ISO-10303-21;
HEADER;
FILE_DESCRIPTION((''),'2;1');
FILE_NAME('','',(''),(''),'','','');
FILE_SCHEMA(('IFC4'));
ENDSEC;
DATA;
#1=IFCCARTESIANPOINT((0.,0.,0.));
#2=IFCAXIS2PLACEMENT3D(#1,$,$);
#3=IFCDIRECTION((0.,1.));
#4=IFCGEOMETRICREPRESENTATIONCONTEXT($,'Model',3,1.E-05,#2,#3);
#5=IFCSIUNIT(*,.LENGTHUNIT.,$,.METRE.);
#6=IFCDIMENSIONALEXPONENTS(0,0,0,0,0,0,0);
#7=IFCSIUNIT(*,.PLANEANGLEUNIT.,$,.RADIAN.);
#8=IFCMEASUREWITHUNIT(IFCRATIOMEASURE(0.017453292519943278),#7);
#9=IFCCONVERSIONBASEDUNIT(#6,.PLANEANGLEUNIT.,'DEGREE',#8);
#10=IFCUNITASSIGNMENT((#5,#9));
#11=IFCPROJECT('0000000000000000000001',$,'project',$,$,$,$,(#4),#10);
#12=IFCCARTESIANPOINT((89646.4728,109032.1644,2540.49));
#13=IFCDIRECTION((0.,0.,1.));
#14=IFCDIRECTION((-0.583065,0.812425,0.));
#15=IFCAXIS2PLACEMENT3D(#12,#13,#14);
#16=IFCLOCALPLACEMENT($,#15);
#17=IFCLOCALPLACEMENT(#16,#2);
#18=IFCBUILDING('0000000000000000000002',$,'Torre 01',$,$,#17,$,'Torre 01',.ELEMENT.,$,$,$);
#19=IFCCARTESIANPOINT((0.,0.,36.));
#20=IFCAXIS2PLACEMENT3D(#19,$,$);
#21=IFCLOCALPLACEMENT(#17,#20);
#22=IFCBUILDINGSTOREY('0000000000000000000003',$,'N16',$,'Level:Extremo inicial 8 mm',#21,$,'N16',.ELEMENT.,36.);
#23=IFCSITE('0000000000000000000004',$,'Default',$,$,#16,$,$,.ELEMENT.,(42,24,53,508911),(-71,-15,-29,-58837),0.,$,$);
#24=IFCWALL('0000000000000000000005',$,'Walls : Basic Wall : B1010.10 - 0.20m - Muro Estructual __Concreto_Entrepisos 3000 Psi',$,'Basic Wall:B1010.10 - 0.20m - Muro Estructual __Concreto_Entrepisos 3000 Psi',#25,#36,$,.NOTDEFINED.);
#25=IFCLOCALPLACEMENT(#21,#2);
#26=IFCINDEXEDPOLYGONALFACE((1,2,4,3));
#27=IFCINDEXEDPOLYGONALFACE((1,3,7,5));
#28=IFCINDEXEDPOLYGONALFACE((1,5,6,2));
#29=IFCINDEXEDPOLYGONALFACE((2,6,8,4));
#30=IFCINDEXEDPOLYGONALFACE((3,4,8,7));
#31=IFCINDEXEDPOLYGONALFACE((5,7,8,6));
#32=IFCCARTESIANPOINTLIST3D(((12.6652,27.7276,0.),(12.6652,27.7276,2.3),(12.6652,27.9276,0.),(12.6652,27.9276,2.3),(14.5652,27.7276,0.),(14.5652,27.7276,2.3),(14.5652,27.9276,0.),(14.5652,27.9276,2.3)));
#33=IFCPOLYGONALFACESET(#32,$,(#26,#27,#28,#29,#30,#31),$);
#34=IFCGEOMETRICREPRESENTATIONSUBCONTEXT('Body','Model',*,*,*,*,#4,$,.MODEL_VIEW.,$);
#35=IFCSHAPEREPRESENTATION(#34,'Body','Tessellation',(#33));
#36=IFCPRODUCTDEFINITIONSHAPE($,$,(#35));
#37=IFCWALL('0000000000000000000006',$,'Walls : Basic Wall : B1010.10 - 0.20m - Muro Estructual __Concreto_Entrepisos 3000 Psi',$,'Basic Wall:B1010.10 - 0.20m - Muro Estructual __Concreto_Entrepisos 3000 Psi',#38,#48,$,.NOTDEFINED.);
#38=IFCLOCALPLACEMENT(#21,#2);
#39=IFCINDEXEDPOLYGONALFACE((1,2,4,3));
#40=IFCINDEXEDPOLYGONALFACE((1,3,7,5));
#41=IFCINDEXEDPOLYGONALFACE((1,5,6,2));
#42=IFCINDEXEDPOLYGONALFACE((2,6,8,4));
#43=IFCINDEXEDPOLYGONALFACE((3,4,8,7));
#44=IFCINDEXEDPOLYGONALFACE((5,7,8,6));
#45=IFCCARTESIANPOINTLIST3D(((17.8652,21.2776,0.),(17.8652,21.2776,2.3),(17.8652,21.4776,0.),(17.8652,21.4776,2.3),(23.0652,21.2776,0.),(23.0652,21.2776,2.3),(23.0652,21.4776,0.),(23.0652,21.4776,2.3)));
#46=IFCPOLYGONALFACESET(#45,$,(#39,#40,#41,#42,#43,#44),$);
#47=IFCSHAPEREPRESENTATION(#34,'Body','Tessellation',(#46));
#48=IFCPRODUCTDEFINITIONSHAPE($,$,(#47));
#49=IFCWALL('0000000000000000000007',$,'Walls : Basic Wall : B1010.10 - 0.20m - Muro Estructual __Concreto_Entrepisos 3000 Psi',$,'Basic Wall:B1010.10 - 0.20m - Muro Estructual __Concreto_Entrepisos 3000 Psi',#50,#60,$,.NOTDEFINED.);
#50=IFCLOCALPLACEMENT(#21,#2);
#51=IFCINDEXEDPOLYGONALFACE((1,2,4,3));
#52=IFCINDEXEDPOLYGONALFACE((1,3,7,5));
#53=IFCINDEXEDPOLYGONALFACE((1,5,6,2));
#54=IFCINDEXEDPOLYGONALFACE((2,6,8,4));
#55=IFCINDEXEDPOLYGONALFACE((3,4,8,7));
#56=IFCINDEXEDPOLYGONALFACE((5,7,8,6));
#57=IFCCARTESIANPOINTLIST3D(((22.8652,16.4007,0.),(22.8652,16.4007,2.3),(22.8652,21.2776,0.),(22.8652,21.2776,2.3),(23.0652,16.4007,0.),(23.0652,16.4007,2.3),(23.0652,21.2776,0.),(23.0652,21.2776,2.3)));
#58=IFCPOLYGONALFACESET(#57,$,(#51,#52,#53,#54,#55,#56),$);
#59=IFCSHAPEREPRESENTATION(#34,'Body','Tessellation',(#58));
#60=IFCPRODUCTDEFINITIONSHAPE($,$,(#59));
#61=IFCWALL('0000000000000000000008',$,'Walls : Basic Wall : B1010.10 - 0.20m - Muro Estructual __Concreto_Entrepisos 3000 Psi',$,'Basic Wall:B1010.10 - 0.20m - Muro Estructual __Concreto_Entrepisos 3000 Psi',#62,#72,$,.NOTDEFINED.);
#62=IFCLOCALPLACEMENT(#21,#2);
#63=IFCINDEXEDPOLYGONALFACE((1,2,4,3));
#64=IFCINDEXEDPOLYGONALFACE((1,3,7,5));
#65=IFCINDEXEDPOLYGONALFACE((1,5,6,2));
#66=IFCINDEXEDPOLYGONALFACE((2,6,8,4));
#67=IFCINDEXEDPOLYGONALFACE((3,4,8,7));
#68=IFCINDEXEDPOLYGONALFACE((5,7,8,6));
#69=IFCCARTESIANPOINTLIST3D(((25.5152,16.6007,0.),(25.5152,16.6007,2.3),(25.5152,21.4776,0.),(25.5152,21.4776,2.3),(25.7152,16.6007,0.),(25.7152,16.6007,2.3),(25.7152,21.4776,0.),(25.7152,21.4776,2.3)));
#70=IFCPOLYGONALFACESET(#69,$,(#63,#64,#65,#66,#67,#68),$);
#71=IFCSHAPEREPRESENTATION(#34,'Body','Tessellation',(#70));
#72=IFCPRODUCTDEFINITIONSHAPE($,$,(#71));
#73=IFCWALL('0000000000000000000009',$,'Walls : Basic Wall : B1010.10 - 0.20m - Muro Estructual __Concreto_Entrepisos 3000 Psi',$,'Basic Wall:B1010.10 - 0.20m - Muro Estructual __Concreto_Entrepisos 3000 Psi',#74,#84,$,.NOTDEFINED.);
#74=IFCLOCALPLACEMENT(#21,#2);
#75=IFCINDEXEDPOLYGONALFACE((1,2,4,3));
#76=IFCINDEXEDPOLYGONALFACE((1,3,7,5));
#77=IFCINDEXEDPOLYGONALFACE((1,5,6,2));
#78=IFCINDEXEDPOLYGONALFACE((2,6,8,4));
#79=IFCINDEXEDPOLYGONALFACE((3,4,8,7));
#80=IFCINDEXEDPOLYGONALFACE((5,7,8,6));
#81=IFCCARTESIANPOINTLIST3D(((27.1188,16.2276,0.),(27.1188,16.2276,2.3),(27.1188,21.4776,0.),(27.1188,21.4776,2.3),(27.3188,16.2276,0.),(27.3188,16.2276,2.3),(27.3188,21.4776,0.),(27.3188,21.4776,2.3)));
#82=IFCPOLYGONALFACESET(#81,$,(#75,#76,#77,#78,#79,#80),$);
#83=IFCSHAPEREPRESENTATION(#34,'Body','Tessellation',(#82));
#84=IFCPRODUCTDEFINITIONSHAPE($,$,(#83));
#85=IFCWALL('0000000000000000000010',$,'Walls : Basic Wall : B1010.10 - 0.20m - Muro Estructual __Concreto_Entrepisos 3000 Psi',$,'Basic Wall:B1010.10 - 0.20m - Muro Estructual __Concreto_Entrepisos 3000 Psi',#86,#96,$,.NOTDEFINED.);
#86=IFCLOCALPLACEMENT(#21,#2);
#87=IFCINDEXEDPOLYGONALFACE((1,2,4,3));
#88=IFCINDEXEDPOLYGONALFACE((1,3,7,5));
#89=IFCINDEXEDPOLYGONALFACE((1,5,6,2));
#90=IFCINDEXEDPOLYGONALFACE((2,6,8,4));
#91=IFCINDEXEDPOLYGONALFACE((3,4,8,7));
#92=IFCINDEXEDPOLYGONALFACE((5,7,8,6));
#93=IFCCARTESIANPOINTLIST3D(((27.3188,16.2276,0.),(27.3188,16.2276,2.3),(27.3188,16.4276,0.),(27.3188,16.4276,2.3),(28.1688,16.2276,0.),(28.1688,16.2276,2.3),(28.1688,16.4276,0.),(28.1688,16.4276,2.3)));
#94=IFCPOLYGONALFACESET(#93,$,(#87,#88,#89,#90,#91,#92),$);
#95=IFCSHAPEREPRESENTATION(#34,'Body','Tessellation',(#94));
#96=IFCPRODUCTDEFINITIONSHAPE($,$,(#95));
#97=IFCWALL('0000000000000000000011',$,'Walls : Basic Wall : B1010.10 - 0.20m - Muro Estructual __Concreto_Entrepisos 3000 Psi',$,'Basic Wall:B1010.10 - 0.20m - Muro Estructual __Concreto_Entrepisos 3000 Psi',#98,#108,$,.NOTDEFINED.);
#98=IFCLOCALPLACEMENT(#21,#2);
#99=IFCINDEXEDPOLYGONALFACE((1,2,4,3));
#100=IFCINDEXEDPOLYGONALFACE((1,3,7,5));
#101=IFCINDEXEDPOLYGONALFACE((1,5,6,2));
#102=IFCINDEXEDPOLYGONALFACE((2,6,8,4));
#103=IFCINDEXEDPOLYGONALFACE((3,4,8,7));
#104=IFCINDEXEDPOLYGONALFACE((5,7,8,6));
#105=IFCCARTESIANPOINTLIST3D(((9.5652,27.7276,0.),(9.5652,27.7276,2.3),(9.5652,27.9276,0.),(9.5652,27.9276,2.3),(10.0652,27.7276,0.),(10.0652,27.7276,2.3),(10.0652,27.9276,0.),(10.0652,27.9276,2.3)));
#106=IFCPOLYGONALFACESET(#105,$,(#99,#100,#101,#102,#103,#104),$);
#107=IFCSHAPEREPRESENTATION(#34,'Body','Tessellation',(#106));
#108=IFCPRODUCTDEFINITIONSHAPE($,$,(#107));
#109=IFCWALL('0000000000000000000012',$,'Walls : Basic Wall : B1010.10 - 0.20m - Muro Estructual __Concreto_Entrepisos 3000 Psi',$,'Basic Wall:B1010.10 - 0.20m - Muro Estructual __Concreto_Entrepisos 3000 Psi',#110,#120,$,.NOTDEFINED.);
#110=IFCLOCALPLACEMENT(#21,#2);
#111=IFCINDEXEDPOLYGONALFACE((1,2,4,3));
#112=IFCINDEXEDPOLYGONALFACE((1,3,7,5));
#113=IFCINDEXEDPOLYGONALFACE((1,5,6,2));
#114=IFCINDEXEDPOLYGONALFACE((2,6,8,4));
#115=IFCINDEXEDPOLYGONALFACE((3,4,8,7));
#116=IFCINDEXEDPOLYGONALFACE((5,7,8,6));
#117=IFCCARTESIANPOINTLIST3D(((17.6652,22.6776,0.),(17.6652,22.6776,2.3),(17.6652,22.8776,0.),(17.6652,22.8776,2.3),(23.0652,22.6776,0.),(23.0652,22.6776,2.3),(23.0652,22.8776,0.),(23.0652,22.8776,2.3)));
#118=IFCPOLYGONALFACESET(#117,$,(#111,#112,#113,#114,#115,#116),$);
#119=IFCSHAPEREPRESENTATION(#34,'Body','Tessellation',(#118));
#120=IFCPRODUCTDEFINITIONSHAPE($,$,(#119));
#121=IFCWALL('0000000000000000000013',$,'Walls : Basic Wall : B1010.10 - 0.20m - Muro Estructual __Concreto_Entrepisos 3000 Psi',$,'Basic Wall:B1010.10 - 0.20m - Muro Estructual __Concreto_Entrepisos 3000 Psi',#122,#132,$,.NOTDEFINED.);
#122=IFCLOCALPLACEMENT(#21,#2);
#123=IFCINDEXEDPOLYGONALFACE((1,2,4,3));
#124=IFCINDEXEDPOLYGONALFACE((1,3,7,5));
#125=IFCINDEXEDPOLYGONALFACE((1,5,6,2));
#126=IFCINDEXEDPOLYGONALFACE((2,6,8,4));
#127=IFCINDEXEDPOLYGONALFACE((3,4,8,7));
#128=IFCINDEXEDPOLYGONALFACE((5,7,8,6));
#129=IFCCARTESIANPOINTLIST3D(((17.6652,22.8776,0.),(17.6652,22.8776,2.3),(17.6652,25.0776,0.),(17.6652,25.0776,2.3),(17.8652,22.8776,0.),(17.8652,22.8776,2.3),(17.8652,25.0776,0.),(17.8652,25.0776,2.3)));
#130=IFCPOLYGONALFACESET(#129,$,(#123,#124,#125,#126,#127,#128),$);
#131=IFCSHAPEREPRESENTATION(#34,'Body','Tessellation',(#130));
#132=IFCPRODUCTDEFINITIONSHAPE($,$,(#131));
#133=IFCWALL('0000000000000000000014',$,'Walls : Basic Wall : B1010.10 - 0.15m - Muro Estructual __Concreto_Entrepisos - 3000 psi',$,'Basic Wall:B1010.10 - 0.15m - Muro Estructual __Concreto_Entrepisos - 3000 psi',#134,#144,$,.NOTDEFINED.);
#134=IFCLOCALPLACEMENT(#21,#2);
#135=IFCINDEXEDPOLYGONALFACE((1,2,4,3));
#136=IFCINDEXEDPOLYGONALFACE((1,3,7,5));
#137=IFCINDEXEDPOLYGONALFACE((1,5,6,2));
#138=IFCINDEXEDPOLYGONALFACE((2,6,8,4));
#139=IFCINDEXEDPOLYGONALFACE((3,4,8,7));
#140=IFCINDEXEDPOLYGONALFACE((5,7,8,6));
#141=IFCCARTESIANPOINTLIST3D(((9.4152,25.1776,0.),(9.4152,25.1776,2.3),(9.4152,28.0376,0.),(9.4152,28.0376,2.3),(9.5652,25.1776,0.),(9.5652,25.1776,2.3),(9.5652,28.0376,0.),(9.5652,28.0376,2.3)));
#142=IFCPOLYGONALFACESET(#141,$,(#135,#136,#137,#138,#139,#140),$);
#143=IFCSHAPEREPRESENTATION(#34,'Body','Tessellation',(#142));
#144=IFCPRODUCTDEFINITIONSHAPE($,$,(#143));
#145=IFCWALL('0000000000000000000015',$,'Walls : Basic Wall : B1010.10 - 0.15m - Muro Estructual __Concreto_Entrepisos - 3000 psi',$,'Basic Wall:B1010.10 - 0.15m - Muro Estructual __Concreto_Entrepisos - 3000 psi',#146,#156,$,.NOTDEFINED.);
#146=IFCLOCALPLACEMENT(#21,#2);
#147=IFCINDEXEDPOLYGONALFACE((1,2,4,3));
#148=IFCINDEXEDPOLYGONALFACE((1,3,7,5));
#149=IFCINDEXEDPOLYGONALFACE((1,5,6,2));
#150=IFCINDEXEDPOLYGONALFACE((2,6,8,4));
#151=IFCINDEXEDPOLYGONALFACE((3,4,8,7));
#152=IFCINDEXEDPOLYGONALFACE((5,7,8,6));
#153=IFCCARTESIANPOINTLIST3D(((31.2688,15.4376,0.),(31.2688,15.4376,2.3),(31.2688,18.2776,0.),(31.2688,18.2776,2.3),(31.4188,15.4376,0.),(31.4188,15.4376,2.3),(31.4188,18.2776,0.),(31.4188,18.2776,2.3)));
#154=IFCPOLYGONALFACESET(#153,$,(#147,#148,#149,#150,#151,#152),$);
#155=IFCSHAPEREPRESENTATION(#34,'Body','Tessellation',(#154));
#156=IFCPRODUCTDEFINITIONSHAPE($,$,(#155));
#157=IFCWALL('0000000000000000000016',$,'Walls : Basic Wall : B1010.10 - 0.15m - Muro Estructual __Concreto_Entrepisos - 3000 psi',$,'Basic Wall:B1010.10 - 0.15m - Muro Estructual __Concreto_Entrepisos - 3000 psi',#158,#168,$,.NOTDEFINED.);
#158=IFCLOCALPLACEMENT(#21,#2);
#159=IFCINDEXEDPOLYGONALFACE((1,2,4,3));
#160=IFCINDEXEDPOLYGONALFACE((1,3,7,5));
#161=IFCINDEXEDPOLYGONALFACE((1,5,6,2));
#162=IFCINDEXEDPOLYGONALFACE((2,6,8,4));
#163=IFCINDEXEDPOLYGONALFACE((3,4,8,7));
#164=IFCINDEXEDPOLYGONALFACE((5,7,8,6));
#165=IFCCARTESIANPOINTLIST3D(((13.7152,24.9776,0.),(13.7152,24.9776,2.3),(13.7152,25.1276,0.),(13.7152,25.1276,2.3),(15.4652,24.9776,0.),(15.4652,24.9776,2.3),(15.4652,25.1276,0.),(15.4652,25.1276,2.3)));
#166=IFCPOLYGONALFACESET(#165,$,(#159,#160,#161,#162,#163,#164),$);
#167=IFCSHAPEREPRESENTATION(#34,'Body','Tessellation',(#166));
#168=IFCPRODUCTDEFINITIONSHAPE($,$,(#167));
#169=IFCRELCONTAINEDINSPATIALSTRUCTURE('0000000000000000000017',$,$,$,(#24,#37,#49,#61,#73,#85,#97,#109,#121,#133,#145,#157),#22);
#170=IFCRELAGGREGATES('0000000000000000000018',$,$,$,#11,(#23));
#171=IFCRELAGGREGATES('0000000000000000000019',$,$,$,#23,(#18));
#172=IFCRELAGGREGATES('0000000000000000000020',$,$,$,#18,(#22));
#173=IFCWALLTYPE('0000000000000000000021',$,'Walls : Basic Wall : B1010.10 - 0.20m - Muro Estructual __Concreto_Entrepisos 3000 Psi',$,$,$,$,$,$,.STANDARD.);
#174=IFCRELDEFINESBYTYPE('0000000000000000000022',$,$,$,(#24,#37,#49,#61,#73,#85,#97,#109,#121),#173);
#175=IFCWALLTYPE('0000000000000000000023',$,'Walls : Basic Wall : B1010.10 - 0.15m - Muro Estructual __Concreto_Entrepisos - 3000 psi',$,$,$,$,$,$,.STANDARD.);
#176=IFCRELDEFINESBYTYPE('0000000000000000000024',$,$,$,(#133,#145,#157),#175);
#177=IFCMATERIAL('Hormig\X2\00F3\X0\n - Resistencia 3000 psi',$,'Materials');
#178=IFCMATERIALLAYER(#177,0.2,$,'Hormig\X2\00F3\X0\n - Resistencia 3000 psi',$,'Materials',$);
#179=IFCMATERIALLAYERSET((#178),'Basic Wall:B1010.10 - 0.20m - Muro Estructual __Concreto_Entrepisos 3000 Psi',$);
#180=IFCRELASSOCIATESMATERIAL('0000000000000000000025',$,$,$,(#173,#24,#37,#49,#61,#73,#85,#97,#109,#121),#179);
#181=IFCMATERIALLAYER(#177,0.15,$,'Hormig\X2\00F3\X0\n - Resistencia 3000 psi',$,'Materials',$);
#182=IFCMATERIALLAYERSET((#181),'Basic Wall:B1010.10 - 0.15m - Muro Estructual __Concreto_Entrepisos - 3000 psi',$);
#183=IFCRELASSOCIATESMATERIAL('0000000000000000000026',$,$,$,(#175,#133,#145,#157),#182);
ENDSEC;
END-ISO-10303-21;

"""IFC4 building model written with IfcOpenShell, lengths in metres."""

from ifc_helpers import new_model, entity, si_unit, converted_unit, direction, frame, frame_2d, origin, place, context, subcontext, project, spatial, rectangle, extrude, material, layer, layer_set, layer_usage, type_object, element, save


model = new_model("IFC4")

# Units and contexts
model_context = context("Model", 3, precision=1e-05, world=origin(), true_north=direction((0.0, 1.0)))
body_context = subcontext(model_context, "Body", "Model", "MODEL_VIEW")
ifc_project = project(units=[si_unit("LENGTHUNIT", "METRE"), converted_unit("PLANEANGLEUNIT", "DEGREE", entity("IfcRatioMeasure", 0.017453292519943278), si_unit("PLANEANGLEUNIT", "RADIAN"), dimensions=[0, 0, 0, 0, 0, 0, 0])], contexts=[model_context])

# Site, building, storey
site_placement = place(None, frame((89646.4728, 109032.1644, 2540.49), z_axis=(0.0, 0.0, 1.0), x_axis=(-0.583065, 0.812425, 0.0)))
site = spatial("IfcSite", under=ifc_project, at=site_placement, Name="Default", CompositionType="ELEMENT", RefLatitude=(42, 24, 53, 508911), RefLongitude=(-71, -15, -29, -58837), RefElevation=0.0)
building_placement = place(site_placement, origin())
building = spatial("IfcBuilding", under=site, at=building_placement, Name="Torre 01", LongName="Torre 01", CompositionType="ELEMENT")
storey_placement = place(building_placement, frame((0.0, 0.0, 36.0)))
storey = spatial("IfcBuildingStorey", under=building, at=storey_placement, Name="N16", ObjectType="Level:Extremo inicial 8 mm", LongName="N16", CompositionType="ELEMENT", Elevation=36.0)

# Walls
ifc_material = material(Name="Hormigón - Resistencia 3000 psi", Category="Materials")
ifc_layer_1 = layer(ifc_material, 0.2, Name="Hormigón - Resistencia 3000 psi", Category="Materials")
ifc_layer_set_1 = layer_set([ifc_layer_1], Name="Basic Wall:B1010.10 - 0.20m - Muro Estructual __Concreto_Entrepisos 3000 Psi")
ifc_layer_usage_1 = layer_usage(ifc_layer_set_1, "AXIS2", "NEGATIVE", 0.1)
wall_type_1 = type_object("IfcWallType", Name="Walls : Basic Wall : B1010.10 - 0.20m - Muro Estructual __Concreto_Entrepisos 3000 Psi", PredefinedType="STANDARD", material=ifc_layer_set_1)
wall_1_placement = place(storey_placement, frame((12.6652, 27.8276, 0.0)))
element("IfcWall", 1, at=wall_1_placement, inside=storey, type_object=wall_type_1, material=ifc_layer_usage_1, Name="Walls : Basic Wall : B1010.10 - 0.20m - Muro Estructual __Concreto_Entrepisos 3000 Psi", ObjectType="Basic Wall:B1010.10 - 0.20m - Muro Estructual __Concreto_Entrepisos 3000 Psi", PredefinedType="NOTDEFINED", context=body_context, shape_type="SweptSolid", body=[
    extrude(rectangle(XDim=1.9, YDim=0.2, at=frame_2d((0.95, 0.0), x_axis=(-1.0, 0.0))), origin(), (0.0, 0.0, 1.0), 2.3),
])
ifc_layer_usage_2 = layer_usage(ifc_layer_set_1, "AXIS2", "NEGATIVE", 0.1)
wall_2_placement = place(storey_placement, frame((17.8652, 21.3776, 0.0)))
element("IfcWall", 2, at=wall_2_placement, inside=storey, type_object=wall_type_1, material=ifc_layer_usage_2, Name="Walls : Basic Wall : B1010.10 - 0.20m - Muro Estructual __Concreto_Entrepisos 3000 Psi", ObjectType="Basic Wall:B1010.10 - 0.20m - Muro Estructual __Concreto_Entrepisos 3000 Psi", PredefinedType="NOTDEFINED", context=body_context, shape_type="SweptSolid", body=[
    extrude(rectangle(XDim=5.2, YDim=0.2, at=frame_2d((2.6, 0.0), x_axis=(-1.0, 0.0))), origin(), (0.0, 0.0, 1.0), 2.3),
])
ifc_layer_usage_3 = layer_usage(ifc_layer_set_1, "AXIS2", "NEGATIVE", 0.1)
wall_3_placement = place(storey_placement, frame((22.9652, 21.2776, 0.0), z_axis=(0.0, 0.0, 1.0), x_axis=(0.0, -1.0, 0.0)))
element("IfcWall", 3, at=wall_3_placement, inside=storey, type_object=wall_type_1, material=ifc_layer_usage_3, Name="Walls : Basic Wall : B1010.10 - 0.20m - Muro Estructual __Concreto_Entrepisos 3000 Psi", ObjectType="Basic Wall:B1010.10 - 0.20m - Muro Estructual __Concreto_Entrepisos 3000 Psi", PredefinedType="NOTDEFINED", context=body_context, shape_type="SweptSolid", body=[
    extrude(rectangle(XDim=4.8769, YDim=0.2, at=frame_2d((2.4384, 0.0), x_axis=(-1.0, 0.0))), origin(), (0.0, 0.0, 1.0), 2.3),
])
ifc_layer_usage_4 = layer_usage(ifc_layer_set_1, "AXIS2", "NEGATIVE", 0.1)
wall_4_placement = place(storey_placement, frame((25.6152, 16.6007, 0.0), z_axis=(0.0, 0.0, 1.0), x_axis=(0.0, 1.0, 0.0)))
element("IfcWall", 4, at=wall_4_placement, inside=storey, type_object=wall_type_1, material=ifc_layer_usage_4, Name="Walls : Basic Wall : B1010.10 - 0.20m - Muro Estructual __Concreto_Entrepisos 3000 Psi", ObjectType="Basic Wall:B1010.10 - 0.20m - Muro Estructual __Concreto_Entrepisos 3000 Psi", PredefinedType="NOTDEFINED", context=body_context, shape_type="SweptSolid", body=[
    extrude(rectangle(XDim=4.8769, YDim=0.2, at=frame_2d((2.4384, 0.0), x_axis=(-1.0, 0.0))), origin(), (0.0, 0.0, 1.0), 2.3),
])
ifc_layer_usage_5 = layer_usage(ifc_layer_set_1, "AXIS2", "NEGATIVE", 0.1)
wall_5_placement = place(storey_placement, frame((27.2188, 16.2276, 0.0), z_axis=(0.0, 0.0, 1.0), x_axis=(0.0, 1.0, 0.0)))
element("IfcWall", 5, at=wall_5_placement, inside=storey, type_object=wall_type_1, material=ifc_layer_usage_5, Name="Walls : Basic Wall : B1010.10 - 0.20m - Muro Estructual __Concreto_Entrepisos 3000 Psi", ObjectType="Basic Wall:B1010.10 - 0.20m - Muro Estructual __Concreto_Entrepisos 3000 Psi", PredefinedType="NOTDEFINED", context=body_context, shape_type="SweptSolid", body=[
    extrude(rectangle(XDim=5.25, YDim=0.2, at=frame_2d((2.625, 0.0), x_axis=(-1.0, 0.0))), origin(), (0.0, 0.0, 1.0), 2.3),
])
ifc_layer_usage_6 = layer_usage(ifc_layer_set_1, "AXIS2", "NEGATIVE", 0.1)
wall_6_placement = place(storey_placement, frame((27.3188, 16.3276, 0.0)))
element("IfcWall", 6, at=wall_6_placement, inside=storey, type_object=wall_type_1, material=ifc_layer_usage_6, Name="Walls : Basic Wall : B1010.10 - 0.20m - Muro Estructual __Concreto_Entrepisos 3000 Psi", ObjectType="Basic Wall:B1010.10 - 0.20m - Muro Estructual __Concreto_Entrepisos 3000 Psi", PredefinedType="NOTDEFINED", context=body_context, shape_type="SweptSolid", body=[
    extrude(rectangle(XDim=0.85, YDim=0.2, at=frame_2d((0.425, 0.0), x_axis=(-1.0, 0.0))), origin(), (0.0, 0.0, 1.0), 2.3),
])
ifc_layer_usage_7 = layer_usage(ifc_layer_set_1, "AXIS2", "NEGATIVE", 0.1)
wall_7_placement = place(storey_placement, frame((9.5652, 27.8276, 0.0)))
element("IfcWall", 7, at=wall_7_placement, inside=storey, type_object=wall_type_1, material=ifc_layer_usage_7, Name="Walls : Basic Wall : B1010.10 - 0.20m - Muro Estructual __Concreto_Entrepisos 3000 Psi", ObjectType="Basic Wall:B1010.10 - 0.20m - Muro Estructual __Concreto_Entrepisos 3000 Psi", PredefinedType="NOTDEFINED", context=body_context, shape_type="SweptSolid", body=[
    extrude(rectangle(XDim=0.5, YDim=0.2, at=frame_2d((0.25, 0.0), x_axis=(-1.0, 0.0))), origin(), (0.0, 0.0, 1.0), 2.3),
])
ifc_layer_usage_8 = layer_usage(ifc_layer_set_1, "AXIS2", "NEGATIVE", 0.1)
wall_8_placement = place(storey_placement, frame((17.6652, 22.7776, 0.0)))
element("IfcWall", 8, at=wall_8_placement, inside=storey, type_object=wall_type_1, material=ifc_layer_usage_8, Name="Walls : Basic Wall : B1010.10 - 0.20m - Muro Estructual __Concreto_Entrepisos 3000 Psi", ObjectType="Basic Wall:B1010.10 - 0.20m - Muro Estructual __Concreto_Entrepisos 3000 Psi", PredefinedType="NOTDEFINED", context=body_context, shape_type="SweptSolid", body=[
    extrude(rectangle(XDim=5.4, YDim=0.2, at=frame_2d((2.7, 0.0), x_axis=(-1.0, 0.0))), origin(), (0.0, 0.0, 1.0), 2.3),
])
ifc_layer_usage_9 = layer_usage(ifc_layer_set_1, "AXIS2", "NEGATIVE", 0.1)
wall_9_placement = place(storey_placement, frame((17.7652, 22.8776, 0.0), z_axis=(0.0, 0.0, 1.0), x_axis=(0.0, 1.0, 0.0)))
element("IfcWall", 9, at=wall_9_placement, inside=storey, type_object=wall_type_1, material=ifc_layer_usage_9, Name="Walls : Basic Wall : B1010.10 - 0.20m - Muro Estructual __Concreto_Entrepisos 3000 Psi", ObjectType="Basic Wall:B1010.10 - 0.20m - Muro Estructual __Concreto_Entrepisos 3000 Psi", PredefinedType="NOTDEFINED", context=body_context, shape_type="SweptSolid", body=[
    extrude(rectangle(XDim=2.2, YDim=0.2, at=frame_2d((1.1, 0.0), x_axis=(-1.0, 0.0))), origin(), (0.0, 0.0, 1.0), 2.3),
])
ifc_layer_2 = layer(ifc_material, 0.15, Name="Hormigón - Resistencia 3000 psi", Category="Materials")
ifc_layer_set_2 = layer_set([ifc_layer_2], Name="Basic Wall:B1010.10 - 0.15m - Muro Estructual __Concreto_Entrepisos - 3000 psi")
ifc_layer_usage_10 = layer_usage(ifc_layer_set_2, "AXIS2", "NEGATIVE", 0.075)
wall_type_2 = type_object("IfcWallType", Name="Walls : Basic Wall : B1010.10 - 0.15m - Muro Estructual __Concreto_Entrepisos - 3000 psi", PredefinedType="STANDARD", material=ifc_layer_set_2)
wall_10_placement = place(storey_placement, frame((9.4902, 28.0376, 0.0), z_axis=(0.0, 0.0, 1.0), x_axis=(0.0, -1.0, 0.0)))
element("IfcWall", 10, at=wall_10_placement, inside=storey, type_object=wall_type_2, material=ifc_layer_usage_10, Name="Walls : Basic Wall : B1010.10 - 0.15m - Muro Estructual __Concreto_Entrepisos - 3000 psi", ObjectType="Basic Wall:B1010.10 - 0.15m - Muro Estructual __Concreto_Entrepisos - 3000 psi", PredefinedType="NOTDEFINED", context=body_context, shape_type="SweptSolid", body=[
    extrude(rectangle(XDim=2.86, YDim=0.15, at=frame_2d((1.43, 0.0), x_axis=(-1.0, 0.0))), origin(), (0.0, 0.0, 1.0), 2.3),
])
ifc_layer_usage_11 = layer_usage(ifc_layer_set_2, "AXIS2", "NEGATIVE", 0.075)
wall_11_placement = place(storey_placement, frame((31.3438, 15.4376, 0.0), z_axis=(0.0, 0.0, 1.0), x_axis=(0.0, 1.0, 0.0)))
element("IfcWall", 11, at=wall_11_placement, inside=storey, type_object=wall_type_2, material=ifc_layer_usage_11, Name="Walls : Basic Wall : B1010.10 - 0.15m - Muro Estructual __Concreto_Entrepisos - 3000 psi", ObjectType="Basic Wall:B1010.10 - 0.15m - Muro Estructual __Concreto_Entrepisos - 3000 psi", PredefinedType="NOTDEFINED", context=body_context, shape_type="SweptSolid", body=[
    extrude(rectangle(XDim=2.84, YDim=0.15, at=frame_2d((1.42, 0.0), x_axis=(-1.0, 0.0))), origin(), (0.0, 0.0, 1.0), 2.3),
])
ifc_layer_usage_12 = layer_usage(ifc_layer_set_2, "AXIS2", "POSITIVE", -0.075)
wall_12_placement = place(storey_placement, frame((13.7152, 25.0526, 0.0)))
element("IfcWall", 12, at=wall_12_placement, inside=storey, type_object=wall_type_2, material=ifc_layer_usage_12, Name="Walls : Basic Wall : B1010.10 - 0.15m - Muro Estructual __Concreto_Entrepisos - 3000 psi", ObjectType="Basic Wall:B1010.10 - 0.15m - Muro Estructual __Concreto_Entrepisos - 3000 psi", PredefinedType="NOTDEFINED", context=body_context, shape_type="SweptSolid", body=[
    extrude(rectangle(XDim=1.75, YDim=0.15, at=frame_2d((0.875, 0.0), x_axis=(-1.0, 0.0))), origin(), (0.0, 0.0, 1.0), 2.3),
])

save(model, "model.ifc")
